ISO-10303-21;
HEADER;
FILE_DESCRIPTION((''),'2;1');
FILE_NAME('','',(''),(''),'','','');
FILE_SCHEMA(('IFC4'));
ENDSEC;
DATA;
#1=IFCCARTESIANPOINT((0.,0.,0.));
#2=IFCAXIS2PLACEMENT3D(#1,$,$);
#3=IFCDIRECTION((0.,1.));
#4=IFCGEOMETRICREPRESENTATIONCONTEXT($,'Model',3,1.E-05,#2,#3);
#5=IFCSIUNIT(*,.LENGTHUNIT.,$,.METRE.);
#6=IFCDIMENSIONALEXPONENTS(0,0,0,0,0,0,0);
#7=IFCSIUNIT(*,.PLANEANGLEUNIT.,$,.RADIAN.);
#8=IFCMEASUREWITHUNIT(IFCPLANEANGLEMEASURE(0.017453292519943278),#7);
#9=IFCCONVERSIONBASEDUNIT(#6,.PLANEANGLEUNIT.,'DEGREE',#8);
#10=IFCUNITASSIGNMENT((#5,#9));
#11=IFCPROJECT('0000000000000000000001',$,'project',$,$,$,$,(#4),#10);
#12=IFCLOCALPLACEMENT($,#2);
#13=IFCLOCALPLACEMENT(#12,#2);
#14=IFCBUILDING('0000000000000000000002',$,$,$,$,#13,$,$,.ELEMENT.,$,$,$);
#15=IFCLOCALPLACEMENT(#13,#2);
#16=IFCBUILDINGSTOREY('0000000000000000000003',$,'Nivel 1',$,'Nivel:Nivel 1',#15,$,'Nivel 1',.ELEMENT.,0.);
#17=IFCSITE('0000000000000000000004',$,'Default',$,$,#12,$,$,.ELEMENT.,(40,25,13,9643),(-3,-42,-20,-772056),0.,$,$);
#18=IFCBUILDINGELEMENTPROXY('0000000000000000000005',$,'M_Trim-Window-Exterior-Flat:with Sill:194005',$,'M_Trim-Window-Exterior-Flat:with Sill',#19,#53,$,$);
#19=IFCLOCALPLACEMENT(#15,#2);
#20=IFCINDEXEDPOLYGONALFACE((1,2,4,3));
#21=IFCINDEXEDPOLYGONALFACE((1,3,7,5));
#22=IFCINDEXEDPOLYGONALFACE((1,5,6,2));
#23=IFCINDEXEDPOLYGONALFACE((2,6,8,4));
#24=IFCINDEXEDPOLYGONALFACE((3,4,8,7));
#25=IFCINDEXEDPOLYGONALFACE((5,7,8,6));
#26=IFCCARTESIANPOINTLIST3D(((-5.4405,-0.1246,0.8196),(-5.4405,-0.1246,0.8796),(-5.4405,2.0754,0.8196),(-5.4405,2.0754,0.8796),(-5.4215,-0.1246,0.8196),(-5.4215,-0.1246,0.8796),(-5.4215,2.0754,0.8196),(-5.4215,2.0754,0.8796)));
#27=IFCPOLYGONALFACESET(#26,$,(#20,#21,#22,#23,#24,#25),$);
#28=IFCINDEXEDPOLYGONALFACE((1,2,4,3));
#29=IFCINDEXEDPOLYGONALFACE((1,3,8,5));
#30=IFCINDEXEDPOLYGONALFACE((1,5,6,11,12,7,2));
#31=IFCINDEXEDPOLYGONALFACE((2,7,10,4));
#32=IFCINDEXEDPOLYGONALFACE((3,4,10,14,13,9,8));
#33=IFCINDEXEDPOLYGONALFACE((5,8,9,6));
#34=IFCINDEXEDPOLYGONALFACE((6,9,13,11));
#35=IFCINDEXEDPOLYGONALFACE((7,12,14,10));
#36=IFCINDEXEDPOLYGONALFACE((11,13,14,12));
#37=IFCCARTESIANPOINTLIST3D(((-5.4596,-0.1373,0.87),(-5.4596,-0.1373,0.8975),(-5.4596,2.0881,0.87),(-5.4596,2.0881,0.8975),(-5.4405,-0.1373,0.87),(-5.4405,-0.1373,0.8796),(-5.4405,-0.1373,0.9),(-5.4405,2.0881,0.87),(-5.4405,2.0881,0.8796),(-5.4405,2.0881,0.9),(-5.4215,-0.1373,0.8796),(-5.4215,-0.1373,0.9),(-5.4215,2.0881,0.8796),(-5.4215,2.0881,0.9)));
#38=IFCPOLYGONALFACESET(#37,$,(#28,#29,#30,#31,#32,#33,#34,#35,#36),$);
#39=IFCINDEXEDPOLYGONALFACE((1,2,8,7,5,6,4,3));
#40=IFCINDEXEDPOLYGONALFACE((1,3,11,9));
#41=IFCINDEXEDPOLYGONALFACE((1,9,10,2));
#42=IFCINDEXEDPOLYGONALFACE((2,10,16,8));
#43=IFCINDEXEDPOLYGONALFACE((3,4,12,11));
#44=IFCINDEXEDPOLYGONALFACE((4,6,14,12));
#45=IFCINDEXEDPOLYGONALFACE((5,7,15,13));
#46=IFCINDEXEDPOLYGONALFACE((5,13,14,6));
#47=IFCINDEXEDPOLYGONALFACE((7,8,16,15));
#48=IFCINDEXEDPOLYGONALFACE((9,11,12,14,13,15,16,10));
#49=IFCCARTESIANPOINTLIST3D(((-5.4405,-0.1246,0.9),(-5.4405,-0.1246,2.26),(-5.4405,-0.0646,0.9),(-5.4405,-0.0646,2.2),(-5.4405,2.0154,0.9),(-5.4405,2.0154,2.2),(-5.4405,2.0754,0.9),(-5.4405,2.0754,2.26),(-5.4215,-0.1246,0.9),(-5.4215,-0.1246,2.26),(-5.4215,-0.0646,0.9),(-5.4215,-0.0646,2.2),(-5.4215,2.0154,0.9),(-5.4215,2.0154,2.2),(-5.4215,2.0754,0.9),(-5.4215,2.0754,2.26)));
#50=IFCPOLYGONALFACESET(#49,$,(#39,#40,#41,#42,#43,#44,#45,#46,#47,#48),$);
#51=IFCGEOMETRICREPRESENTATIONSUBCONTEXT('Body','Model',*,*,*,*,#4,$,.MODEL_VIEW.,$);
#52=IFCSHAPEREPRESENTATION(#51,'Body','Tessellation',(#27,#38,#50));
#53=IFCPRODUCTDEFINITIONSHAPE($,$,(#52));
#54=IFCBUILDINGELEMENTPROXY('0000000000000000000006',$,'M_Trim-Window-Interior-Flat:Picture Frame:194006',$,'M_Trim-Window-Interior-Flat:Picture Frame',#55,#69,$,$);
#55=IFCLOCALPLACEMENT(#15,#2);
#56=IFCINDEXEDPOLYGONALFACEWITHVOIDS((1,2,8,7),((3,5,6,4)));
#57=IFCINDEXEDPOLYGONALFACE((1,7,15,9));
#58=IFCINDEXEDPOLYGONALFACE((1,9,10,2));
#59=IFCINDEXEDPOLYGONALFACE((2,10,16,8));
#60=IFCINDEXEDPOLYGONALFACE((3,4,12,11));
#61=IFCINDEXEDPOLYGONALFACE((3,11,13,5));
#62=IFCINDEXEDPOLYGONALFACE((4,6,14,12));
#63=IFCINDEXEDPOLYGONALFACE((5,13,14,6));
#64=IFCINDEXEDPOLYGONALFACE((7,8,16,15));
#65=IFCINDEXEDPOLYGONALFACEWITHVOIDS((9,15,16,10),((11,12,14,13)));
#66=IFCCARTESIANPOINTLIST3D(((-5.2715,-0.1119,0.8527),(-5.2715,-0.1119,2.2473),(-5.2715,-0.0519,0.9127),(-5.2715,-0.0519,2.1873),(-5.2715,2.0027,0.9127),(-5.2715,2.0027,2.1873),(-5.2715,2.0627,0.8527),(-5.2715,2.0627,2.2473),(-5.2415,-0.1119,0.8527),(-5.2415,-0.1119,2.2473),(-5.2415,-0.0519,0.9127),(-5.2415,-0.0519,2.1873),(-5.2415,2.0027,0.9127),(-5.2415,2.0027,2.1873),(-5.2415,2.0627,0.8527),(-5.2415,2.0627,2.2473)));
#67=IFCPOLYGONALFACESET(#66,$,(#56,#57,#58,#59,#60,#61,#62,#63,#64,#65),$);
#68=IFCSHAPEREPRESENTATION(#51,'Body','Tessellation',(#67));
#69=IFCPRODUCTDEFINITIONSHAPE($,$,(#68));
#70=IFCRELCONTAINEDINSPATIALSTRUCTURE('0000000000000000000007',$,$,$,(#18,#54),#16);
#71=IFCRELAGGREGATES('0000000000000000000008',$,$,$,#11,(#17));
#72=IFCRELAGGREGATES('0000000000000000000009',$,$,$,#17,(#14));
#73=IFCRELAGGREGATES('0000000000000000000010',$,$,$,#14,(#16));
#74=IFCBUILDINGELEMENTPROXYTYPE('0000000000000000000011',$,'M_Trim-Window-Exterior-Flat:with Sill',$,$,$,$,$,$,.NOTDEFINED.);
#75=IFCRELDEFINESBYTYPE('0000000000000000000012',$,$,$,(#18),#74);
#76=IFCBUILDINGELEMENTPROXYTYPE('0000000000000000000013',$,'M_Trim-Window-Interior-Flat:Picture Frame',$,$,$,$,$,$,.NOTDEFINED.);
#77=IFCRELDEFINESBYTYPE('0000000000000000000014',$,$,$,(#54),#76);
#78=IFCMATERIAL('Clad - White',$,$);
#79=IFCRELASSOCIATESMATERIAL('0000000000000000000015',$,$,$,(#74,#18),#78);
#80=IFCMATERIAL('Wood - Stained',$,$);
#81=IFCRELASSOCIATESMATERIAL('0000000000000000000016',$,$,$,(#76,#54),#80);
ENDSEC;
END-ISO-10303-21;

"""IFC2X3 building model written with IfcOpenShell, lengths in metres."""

from ifc_helpers import new_model, entity, si_unit, converted_unit, direction, frame, frame_2d, origin, place, context, subcontext, project, spatial, polyline, rectangle, outline, extrude, source, transform, mapped, material, type_object, type_shapes, element, save


model = new_model("IFC2X3")

# Units and contexts
model_context = context("Model", 3, precision=1e-05, world=origin(), true_north=direction((0.0, 1.0)))
body_context = subcontext(model_context, "Body", "Model", "MODEL_VIEW")
ifc_project = project(units=[si_unit("LENGTHUNIT", "METRE"), converted_unit("PLANEANGLEUNIT", "DEGREE", entity("IfcPlaneAngleMeasure", 0.017453292519943278), si_unit("PLANEANGLEUNIT", "RADIAN"), dimensions=[0, 0, 0, 0, 0, 0, 0])], contexts=[model_context])

# Site, building, storey
site_placement = place(None, origin())
site = spatial("IfcSite", under=ifc_project, at=site_placement, Name="Default", CompositionType="ELEMENT", RefLatitude=(40, 25, 13, 9643), RefLongitude=(-3, -42, -20, -772056), RefElevation=0.0)
building_placement = place(site_placement, origin())
building = spatial("IfcBuilding", under=site, at=building_placement, CompositionType="ELEMENT")
storey_placement = place(building_placement, origin())
storey = spatial("IfcBuildingStorey", under=building, at=storey_placement, Name="Nivel 1", ObjectType="Nivel:Nivel 1", LongName="Nivel 1", CompositionType="ELEMENT", Elevation=0.0)

# Building element proxies
ifc_material_1 = material(Name="Clad - White")
ifc_material_2 = material(Name="Wood - Stained")
building_element_proxy_type_1 = type_object("IfcBuildingElementProxyType", Name="M_Trim-Window-Exterior-Flat:with Sill", PredefinedType="NOTDEFINED", material=ifc_material_1)
shared_shape_1 = source(origin(), body_context, "Body", "SweptSolid", [
    extrude(rectangle(XDim=2.2, YDim=0.06, at=frame_2d((0.0, 0.0), x_axis=(1.0, 0.0))), frame((0.0, -1.3504, 0.0), z_axis=(0.0, 0.0, 1.0), x_axis=(-1.0, 0.0, 0.0)), (0.0, 0.0, 1.0), 0.019),
    extrude(outline(polyline([(-0.019, -0.0152), (0.0, -0.0152), (0.0, -0.0057), (0.019, -0.0057), (0.019, 0.0148), (0.0, 0.0148), (-0.019, 0.0123), (-0.019, -0.0152)])), frame((-1.1127, -1.3148, 0.019), z_axis=(1.0, 0.0, 0.0), x_axis=(0.0, 0.0, -1.0)), (0.0, 0.0, 1.0), 2.2254),
    extrude(outline(polyline([(-0.695, -1.1), (0.665, -1.1), (0.665, -1.04), (-0.635, -1.04), (-0.635, 1.04), (0.665, 1.04), (0.665, 1.1), (-0.695, 1.1), (-0.695, -1.1)])), frame((0.0, -0.635, 0.0), z_axis=(0.0, 0.0, 1.0), x_axis=(0.0, -1.0, 0.0)), (0.0, 0.0, 1.0), 0.019),
])
type_shapes(building_element_proxy_type_1, [shared_shape_1])
proxy_1_placement = place(storey_placement, frame((-5.4215, 0.9754, 2.2), z_axis=(-1.0, 0.0, 0.0), x_axis=(0.0, -1.0, 0.0)))
element("IfcBuildingElementProxy", 1, at=proxy_1_placement, inside=storey, type_object=building_element_proxy_type_1, material=ifc_material_1, Name="M_Trim-Window-Exterior-Flat:with Sill:194005", ObjectType="M_Trim-Window-Exterior-Flat:with Sill", context=body_context, shape_type="MappedRepresentation", body=[
    mapped(shared_shape_1, transform((0.0, 0.0, 0.0), scale=1.0)),
])
building_element_proxy_type_2 = type_object("IfcBuildingElementProxyType", Name="M_Trim-Window-Interior-Flat:Picture Frame", PredefinedType="NOTDEFINED", material=ifc_material_2)
shared_shape_2 = source(origin(), body_context, "Body", "SweptSolid", [
    extrude(outline(polyline([(-1.0873, -0.6973), (1.0873, -0.6973), (1.0873, 0.6973), (-1.0873, 0.6973), (-1.0873, -0.6973)]), holes=[polyline([(-1.0273, -0.6373), (-1.0273, 0.6373), (1.0273, 0.6373), (1.0273, -0.6373), (-1.0273, -0.6373)])]), frame((0.0, -0.65, 0.0), z_axis=(0.0, 0.0, 1.0), x_axis=(-1.0, 0.0, 0.0)), (0.0, 0.0, 1.0), 0.03),
])
type_shapes(building_element_proxy_type_2, [shared_shape_2])
proxy_2_placement = place(storey_placement, frame((-5.2715, 0.9754, 2.2), z_axis=(1.0, 0.0, 0.0), x_axis=(0.0, 1.0, 0.0)))
element("IfcBuildingElementProxy", 2, at=proxy_2_placement, inside=storey, type_object=building_element_proxy_type_2, material=ifc_material_2, Name="M_Trim-Window-Interior-Flat:Picture Frame:194006", ObjectType="M_Trim-Window-Interior-Flat:Picture Frame", context=body_context, shape_type="MappedRepresentation", body=[
    mapped(shared_shape_2, transform((0.0, 0.0, 0.0), scale=1.0)),
])

save(model, "model.ifc")
